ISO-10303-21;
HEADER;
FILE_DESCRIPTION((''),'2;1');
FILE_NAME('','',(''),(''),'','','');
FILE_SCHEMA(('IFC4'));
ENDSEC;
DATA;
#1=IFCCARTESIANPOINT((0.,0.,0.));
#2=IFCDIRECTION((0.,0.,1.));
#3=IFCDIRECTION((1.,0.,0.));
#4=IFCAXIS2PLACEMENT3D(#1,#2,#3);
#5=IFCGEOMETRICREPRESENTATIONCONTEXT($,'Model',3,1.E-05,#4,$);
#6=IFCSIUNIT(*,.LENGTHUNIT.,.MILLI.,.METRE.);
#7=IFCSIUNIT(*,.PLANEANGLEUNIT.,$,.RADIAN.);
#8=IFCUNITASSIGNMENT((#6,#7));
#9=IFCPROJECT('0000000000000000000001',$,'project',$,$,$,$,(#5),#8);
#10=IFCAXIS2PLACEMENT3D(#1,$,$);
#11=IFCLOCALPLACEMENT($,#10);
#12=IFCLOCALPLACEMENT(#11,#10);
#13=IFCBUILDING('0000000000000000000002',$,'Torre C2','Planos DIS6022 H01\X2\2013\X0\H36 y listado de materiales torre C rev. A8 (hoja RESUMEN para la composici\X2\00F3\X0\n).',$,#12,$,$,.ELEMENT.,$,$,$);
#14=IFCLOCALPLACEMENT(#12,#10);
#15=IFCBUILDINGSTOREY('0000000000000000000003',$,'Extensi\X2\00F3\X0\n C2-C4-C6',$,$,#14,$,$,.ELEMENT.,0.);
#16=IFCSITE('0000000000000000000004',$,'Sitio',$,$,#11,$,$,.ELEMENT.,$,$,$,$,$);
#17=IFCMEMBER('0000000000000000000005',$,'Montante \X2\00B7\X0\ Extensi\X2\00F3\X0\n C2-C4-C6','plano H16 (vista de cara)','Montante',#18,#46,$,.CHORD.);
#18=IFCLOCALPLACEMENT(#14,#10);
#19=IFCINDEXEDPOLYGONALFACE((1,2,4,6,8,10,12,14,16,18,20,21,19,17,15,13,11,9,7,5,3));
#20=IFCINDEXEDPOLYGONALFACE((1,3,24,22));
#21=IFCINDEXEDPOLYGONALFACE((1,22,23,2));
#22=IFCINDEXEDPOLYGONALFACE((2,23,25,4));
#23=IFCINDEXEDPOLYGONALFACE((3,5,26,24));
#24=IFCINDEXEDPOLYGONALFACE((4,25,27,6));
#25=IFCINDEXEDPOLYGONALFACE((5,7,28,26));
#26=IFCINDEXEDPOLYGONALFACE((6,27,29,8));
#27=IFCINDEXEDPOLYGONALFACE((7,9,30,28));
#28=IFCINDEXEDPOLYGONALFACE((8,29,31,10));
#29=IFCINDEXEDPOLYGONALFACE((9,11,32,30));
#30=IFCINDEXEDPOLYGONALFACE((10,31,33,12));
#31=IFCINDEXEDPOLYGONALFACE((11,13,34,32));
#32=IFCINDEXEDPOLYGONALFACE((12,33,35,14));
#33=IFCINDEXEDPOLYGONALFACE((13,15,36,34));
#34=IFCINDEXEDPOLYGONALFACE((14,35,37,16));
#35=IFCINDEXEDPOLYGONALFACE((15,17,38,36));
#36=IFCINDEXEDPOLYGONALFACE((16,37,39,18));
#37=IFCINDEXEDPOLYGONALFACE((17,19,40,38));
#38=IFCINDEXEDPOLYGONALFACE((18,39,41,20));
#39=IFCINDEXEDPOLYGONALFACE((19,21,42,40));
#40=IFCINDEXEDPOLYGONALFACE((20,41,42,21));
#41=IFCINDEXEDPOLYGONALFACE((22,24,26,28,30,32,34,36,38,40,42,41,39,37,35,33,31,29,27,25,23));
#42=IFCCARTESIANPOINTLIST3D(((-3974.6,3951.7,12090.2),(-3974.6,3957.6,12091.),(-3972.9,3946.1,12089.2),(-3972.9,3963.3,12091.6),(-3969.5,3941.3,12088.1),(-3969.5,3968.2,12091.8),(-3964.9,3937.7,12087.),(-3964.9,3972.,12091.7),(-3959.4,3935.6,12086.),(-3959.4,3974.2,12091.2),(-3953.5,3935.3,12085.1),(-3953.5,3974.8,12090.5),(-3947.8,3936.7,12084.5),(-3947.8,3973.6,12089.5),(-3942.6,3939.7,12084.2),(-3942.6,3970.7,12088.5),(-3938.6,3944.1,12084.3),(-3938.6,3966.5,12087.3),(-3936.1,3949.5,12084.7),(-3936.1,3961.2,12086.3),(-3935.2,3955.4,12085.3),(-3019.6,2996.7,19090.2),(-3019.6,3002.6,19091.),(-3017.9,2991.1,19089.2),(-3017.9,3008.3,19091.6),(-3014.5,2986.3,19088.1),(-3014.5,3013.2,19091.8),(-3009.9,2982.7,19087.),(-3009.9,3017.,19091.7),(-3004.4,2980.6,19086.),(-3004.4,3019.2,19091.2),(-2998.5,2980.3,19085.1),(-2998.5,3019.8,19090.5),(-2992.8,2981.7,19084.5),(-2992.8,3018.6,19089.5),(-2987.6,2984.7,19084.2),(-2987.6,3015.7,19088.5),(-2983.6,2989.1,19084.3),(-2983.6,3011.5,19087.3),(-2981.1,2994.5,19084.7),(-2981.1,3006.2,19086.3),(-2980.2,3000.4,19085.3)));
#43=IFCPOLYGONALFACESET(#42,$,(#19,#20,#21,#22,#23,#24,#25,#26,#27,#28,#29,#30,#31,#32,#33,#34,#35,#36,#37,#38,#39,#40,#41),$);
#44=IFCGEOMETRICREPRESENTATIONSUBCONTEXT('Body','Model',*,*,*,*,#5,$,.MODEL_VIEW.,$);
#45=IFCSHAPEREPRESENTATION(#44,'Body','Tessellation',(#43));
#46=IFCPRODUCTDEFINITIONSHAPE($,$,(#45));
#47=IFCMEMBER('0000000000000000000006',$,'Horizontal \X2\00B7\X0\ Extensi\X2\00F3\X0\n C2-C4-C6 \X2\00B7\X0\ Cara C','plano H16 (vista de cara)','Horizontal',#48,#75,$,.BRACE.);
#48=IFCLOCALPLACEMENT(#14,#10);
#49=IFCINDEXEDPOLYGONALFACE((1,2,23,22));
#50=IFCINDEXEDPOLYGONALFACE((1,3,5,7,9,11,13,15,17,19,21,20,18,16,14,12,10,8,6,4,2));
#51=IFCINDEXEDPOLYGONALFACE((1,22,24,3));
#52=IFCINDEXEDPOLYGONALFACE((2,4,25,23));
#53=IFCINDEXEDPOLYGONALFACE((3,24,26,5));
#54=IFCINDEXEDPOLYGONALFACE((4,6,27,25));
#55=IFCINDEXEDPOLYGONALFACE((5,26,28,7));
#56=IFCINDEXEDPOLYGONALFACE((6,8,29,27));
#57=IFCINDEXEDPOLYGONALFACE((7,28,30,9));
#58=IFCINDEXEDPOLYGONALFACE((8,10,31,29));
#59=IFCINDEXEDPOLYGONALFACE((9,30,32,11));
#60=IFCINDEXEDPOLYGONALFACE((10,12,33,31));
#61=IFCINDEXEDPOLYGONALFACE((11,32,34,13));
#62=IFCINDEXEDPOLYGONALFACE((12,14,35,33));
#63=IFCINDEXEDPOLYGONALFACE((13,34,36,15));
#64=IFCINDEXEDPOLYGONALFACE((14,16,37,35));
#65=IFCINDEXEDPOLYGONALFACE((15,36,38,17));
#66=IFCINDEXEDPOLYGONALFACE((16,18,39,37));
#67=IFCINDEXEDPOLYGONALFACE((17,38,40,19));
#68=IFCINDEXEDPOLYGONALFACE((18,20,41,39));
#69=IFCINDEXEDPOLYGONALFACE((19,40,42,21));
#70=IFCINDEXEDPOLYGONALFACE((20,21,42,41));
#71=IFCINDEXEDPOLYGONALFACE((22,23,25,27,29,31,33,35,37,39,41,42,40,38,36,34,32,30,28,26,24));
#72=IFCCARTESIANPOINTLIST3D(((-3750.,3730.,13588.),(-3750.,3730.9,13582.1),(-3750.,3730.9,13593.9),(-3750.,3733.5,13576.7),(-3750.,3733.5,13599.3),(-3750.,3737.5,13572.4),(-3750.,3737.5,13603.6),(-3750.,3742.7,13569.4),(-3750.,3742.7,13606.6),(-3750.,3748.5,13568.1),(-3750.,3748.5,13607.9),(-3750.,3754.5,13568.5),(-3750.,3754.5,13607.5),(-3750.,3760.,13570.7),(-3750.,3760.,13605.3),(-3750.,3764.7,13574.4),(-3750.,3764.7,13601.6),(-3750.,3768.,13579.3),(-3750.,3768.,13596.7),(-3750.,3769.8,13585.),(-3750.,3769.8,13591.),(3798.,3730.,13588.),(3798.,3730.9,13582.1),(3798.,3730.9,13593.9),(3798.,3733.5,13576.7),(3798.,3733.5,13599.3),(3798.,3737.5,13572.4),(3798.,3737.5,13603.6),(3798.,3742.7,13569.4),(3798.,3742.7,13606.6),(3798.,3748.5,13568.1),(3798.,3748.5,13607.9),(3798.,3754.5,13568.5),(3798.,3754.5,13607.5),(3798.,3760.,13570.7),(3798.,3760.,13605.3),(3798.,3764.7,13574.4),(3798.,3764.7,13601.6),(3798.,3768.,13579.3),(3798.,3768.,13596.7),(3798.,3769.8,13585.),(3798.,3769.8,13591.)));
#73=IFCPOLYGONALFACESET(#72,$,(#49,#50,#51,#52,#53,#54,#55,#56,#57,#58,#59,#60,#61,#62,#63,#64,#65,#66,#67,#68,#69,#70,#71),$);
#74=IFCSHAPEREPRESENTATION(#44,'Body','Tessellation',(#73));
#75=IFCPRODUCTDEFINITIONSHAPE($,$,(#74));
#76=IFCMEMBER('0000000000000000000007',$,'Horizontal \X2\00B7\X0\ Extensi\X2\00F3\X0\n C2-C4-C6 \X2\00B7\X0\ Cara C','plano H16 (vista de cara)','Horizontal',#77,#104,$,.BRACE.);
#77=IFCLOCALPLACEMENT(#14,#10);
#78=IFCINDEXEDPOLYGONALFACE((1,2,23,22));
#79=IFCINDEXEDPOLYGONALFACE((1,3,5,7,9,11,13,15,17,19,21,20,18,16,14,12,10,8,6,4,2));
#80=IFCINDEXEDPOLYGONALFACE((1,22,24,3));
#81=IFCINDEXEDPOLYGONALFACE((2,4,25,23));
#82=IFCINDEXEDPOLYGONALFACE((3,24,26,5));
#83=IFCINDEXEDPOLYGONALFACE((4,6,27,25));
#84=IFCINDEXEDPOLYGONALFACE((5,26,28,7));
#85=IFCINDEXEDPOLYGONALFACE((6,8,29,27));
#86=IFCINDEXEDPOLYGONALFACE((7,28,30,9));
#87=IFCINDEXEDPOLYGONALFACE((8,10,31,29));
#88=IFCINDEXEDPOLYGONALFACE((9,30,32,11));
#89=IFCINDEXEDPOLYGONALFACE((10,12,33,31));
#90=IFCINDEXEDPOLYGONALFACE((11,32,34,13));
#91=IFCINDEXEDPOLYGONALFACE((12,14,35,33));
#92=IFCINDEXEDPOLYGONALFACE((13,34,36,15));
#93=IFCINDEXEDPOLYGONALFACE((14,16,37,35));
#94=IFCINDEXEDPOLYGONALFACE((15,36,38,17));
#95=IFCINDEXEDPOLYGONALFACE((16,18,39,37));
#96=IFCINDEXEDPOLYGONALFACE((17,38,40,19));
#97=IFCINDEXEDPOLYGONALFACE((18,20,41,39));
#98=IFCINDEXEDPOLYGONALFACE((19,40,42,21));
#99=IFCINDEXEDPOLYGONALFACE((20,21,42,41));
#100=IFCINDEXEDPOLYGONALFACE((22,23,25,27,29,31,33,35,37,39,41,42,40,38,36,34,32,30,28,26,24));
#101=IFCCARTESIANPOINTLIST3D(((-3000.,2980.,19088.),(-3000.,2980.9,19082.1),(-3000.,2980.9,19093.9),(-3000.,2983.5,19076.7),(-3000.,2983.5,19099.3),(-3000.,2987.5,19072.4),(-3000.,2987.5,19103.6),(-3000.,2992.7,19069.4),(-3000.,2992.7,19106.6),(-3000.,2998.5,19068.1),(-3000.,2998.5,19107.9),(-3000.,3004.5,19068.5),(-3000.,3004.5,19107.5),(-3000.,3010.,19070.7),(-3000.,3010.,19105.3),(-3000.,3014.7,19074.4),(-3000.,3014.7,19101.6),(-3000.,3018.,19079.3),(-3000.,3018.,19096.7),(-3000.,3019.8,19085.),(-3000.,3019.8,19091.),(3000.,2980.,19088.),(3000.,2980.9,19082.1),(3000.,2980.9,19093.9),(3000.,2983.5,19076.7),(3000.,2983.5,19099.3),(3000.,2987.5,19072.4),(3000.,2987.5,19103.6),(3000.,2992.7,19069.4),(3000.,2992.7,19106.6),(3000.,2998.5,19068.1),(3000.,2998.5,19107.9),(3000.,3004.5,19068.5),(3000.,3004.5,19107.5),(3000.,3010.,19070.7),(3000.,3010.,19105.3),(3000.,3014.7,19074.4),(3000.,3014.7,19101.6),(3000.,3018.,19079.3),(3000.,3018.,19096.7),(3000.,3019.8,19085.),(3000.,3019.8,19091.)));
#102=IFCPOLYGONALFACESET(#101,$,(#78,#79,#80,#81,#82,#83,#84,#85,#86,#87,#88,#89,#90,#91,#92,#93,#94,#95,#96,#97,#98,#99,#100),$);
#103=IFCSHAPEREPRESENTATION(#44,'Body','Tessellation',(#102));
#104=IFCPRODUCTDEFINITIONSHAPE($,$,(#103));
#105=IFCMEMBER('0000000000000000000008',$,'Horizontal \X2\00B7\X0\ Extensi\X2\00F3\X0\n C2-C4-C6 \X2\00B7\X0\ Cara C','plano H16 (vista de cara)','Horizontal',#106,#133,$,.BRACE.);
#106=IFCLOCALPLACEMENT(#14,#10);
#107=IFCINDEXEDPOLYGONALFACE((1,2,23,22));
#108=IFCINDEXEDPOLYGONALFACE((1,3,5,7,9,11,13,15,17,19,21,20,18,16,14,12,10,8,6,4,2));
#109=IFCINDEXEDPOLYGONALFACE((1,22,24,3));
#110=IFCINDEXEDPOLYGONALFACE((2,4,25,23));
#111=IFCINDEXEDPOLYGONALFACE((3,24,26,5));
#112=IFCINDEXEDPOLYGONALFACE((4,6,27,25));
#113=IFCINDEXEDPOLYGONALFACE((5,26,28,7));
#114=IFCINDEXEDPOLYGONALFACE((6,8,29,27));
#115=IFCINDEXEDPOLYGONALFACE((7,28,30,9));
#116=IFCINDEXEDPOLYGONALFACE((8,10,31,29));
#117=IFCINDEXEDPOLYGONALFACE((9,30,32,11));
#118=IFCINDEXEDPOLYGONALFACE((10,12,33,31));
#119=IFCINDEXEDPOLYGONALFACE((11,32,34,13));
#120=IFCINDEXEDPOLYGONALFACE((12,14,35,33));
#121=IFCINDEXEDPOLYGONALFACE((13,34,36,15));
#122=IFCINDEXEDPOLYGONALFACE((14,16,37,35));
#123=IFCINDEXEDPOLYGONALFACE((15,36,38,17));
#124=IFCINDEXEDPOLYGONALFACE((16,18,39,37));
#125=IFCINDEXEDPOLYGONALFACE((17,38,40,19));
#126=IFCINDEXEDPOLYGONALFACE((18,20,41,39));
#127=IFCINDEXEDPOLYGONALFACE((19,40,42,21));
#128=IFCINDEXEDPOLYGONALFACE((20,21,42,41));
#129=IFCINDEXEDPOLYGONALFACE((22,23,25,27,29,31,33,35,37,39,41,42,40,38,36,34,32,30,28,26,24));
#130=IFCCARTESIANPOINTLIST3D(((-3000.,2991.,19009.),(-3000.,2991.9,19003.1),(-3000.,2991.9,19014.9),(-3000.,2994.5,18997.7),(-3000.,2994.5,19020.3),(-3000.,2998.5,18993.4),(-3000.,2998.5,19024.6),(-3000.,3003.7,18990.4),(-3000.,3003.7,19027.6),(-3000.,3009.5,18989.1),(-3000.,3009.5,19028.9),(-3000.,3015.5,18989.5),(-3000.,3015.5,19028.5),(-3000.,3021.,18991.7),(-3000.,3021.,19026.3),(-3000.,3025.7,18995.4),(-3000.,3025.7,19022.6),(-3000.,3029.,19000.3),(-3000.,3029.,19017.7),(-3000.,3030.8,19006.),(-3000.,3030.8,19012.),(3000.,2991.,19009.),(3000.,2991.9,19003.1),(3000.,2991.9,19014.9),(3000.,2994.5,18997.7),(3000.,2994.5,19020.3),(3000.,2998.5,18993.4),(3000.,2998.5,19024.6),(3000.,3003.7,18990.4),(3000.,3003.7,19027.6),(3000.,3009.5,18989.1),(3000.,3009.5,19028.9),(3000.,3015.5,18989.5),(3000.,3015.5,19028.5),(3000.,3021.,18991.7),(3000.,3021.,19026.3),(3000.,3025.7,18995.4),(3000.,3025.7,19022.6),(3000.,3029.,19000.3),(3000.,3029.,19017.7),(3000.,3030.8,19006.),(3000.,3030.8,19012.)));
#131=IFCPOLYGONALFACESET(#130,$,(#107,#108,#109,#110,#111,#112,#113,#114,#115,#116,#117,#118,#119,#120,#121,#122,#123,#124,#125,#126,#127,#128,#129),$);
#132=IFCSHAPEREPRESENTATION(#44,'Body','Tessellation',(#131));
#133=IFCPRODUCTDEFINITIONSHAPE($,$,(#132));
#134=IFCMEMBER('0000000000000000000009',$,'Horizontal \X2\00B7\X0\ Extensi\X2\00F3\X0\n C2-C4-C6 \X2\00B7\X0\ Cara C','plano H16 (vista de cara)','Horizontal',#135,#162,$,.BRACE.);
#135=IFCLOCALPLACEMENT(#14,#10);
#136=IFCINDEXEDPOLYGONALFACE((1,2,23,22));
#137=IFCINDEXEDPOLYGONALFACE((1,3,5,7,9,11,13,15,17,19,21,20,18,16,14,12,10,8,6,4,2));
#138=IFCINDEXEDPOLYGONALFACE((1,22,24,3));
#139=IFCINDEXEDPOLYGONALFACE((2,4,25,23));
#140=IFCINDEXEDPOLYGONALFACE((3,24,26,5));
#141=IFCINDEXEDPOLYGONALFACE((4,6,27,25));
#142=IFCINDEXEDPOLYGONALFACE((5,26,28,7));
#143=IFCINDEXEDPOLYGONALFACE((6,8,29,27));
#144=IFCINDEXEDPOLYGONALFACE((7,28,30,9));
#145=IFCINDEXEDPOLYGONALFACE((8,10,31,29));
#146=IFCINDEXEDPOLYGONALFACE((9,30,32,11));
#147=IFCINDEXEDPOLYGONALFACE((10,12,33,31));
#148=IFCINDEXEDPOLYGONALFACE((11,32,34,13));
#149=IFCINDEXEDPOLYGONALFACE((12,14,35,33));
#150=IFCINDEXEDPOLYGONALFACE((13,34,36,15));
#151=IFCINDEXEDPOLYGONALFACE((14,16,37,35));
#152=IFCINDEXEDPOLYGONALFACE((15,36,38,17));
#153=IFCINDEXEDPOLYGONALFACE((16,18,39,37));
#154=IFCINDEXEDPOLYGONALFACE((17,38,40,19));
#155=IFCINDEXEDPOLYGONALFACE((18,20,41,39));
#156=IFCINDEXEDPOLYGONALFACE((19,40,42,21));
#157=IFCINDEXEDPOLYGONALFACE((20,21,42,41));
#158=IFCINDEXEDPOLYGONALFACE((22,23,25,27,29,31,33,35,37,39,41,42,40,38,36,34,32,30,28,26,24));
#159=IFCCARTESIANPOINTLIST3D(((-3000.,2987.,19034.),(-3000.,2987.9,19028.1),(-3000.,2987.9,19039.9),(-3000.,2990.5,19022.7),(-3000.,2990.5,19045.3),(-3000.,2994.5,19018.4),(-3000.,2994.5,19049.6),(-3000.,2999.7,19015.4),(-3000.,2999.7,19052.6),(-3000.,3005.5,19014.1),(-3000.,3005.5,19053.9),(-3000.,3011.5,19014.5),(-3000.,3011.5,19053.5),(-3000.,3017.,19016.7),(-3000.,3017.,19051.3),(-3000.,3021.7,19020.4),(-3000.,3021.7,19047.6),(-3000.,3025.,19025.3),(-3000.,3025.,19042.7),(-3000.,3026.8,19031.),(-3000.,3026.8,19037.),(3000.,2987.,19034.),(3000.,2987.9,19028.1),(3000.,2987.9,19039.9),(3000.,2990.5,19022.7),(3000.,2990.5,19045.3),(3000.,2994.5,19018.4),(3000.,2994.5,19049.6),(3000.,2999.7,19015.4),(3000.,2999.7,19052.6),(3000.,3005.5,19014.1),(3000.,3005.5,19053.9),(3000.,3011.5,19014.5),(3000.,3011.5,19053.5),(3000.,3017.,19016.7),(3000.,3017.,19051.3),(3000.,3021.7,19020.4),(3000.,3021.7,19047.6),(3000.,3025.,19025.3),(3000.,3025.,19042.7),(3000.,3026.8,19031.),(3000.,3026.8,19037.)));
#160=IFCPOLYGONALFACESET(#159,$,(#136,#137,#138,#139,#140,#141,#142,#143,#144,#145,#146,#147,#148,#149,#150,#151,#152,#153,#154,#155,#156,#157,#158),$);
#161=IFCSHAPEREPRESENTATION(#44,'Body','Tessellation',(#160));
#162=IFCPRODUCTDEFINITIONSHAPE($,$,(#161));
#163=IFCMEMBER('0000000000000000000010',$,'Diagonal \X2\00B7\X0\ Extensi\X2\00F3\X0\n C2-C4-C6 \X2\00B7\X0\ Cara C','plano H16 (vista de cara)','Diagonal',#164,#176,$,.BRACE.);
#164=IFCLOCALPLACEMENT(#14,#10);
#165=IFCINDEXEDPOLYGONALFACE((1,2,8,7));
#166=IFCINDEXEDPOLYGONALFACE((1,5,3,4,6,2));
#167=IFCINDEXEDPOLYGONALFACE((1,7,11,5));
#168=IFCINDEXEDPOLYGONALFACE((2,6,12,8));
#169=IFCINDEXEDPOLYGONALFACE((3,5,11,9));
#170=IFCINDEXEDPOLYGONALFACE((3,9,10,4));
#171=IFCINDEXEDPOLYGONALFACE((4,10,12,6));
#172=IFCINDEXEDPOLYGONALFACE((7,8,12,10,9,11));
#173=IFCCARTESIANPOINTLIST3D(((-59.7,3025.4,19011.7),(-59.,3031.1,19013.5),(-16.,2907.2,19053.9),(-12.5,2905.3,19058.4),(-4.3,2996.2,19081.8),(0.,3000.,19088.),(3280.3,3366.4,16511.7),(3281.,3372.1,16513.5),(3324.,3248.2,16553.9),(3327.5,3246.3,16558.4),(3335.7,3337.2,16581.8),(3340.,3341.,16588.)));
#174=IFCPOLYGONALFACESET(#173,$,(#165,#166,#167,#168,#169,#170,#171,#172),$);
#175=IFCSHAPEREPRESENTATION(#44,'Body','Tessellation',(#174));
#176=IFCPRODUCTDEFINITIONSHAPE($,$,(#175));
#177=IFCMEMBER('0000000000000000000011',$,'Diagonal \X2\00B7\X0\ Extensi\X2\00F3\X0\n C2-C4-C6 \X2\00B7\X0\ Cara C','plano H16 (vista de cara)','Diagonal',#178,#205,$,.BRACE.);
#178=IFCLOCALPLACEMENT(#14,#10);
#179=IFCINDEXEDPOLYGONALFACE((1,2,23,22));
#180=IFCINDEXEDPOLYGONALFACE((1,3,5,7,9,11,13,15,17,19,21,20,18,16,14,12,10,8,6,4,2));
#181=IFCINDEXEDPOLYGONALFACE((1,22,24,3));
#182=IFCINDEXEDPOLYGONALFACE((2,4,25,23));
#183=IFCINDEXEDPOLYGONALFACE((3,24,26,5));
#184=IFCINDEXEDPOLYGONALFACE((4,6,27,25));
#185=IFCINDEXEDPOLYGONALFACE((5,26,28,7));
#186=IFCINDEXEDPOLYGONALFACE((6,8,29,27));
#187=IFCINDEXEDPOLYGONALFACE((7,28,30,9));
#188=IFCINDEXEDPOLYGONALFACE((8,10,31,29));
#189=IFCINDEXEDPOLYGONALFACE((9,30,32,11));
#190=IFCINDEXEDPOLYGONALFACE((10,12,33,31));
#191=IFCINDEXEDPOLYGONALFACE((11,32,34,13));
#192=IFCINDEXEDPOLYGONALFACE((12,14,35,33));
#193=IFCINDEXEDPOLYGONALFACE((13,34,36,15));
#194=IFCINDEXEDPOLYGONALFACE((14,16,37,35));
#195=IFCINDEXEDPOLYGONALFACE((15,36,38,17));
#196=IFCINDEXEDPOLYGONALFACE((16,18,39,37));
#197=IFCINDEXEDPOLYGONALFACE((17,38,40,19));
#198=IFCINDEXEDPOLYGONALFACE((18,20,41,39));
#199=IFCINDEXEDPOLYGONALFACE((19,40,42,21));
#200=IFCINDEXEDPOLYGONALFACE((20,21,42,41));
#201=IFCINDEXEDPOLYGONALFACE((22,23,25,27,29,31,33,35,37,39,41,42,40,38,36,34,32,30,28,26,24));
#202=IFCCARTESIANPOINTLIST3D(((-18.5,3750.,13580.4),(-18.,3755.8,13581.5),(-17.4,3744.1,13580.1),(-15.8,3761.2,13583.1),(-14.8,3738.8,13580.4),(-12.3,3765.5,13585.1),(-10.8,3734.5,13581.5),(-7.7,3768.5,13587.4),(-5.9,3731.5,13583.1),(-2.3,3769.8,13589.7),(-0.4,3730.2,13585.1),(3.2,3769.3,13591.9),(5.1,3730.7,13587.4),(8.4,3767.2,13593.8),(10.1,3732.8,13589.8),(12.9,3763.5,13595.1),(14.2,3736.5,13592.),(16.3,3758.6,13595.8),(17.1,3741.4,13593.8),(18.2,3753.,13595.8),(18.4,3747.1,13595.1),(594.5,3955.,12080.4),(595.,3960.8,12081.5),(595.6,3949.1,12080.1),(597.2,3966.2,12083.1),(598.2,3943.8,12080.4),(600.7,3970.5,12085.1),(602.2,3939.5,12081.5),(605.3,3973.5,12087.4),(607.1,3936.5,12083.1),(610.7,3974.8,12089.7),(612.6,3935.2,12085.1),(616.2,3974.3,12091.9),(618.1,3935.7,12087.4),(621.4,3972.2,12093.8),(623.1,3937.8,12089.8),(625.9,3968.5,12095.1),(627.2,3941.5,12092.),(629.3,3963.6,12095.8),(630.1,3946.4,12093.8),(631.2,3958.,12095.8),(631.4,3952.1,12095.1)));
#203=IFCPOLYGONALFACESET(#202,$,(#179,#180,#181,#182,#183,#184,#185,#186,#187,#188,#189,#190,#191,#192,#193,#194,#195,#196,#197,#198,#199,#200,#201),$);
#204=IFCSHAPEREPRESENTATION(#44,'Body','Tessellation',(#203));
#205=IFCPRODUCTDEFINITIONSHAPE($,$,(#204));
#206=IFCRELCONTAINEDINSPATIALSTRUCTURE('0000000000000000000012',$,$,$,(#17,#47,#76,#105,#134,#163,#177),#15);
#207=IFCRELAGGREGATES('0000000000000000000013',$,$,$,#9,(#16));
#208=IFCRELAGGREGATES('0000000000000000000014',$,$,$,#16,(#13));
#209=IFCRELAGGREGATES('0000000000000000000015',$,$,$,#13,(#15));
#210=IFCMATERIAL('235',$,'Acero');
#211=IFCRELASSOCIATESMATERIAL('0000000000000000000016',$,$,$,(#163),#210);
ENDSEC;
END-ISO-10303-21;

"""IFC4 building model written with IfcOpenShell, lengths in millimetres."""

from ifc_helpers import new_model, si_unit, frame, frame_2d, origin, origin_with_axes, place, context, subcontext, project, spatial, circle, l_section, extrude, material, element, save


model = new_model("IFC4")

# Units and contexts
model_context = context("Model", 3, precision=1e-05, world=origin_with_axes())
body_context = subcontext(model_context, "Body", "Model", "MODEL_VIEW")
ifc_project = project(units=[si_unit("LENGTHUNIT", "METRE", prefix="MILLI"), si_unit("PLANEANGLEUNIT", "RADIAN")], contexts=[model_context])

# Site, building, storey
site_placement = place(None, origin())
site = spatial("IfcSite", under=ifc_project, at=site_placement, Name="Sitio", CompositionType="ELEMENT")
building_placement = place(site_placement, origin())
building = spatial("IfcBuilding", under=site, at=building_placement, Name="Torre C2", Description="Planos DIS6022 H01–H36 y listado de materiales torre C rev. A8 (hoja RESUMEN para la composición).", CompositionType="ELEMENT")
storey_placement = place(building_placement, origin())
storey = spatial("IfcBuildingStorey", under=building, at=storey_placement, Name="Extensión C2-C4-C6", CompositionType="ELEMENT", Elevation=0.0)

# Members
member_1_placement = place(storey_placement, frame((-3000.0, 3000.0, 19088.0), z_axis=(-0.133958, 0.133958, -0.981891), x_axis=(0.990987, 0.018108, -0.132728)))
element("IfcMember", 1, at=member_1_placement, inside=storey, Name="Montante · Extensión C2-C4-C6", Description="plano H16 (vista de cara)", ObjectType="Montante", PredefinedType="CHORD", context=body_context, shape_type="SweptSolid", body=[
    extrude(circle(Radius=20.0), None, (0.0, 0.0, 1.0), 7129.1),
])
member_2_placement = place(storey_placement, frame((-3750.0, 3750.0, 13588.0), z_axis=(1.0, 0.0, 0.0), x_axis=(0.0, -1.0, 0.0)))
element("IfcMember", 2, at=member_2_placement, inside=storey, Name="Horizontal · Extensión C2-C4-C6 · Cara C", Description="plano H16 (vista de cara)", ObjectType="Horizontal", PredefinedType="BRACE", context=body_context, shape_type="SweptSolid", body=[
    extrude(circle(Radius=20.0), None, (0.0, 0.0, 1.0), 7548.0),
])
for number, where, z_axis, x_axis, name in (
    (3, (-3000.0, 3000.0, 19088.0), (1.0, 0.0, 0.0), (0.0, -1.0, 0.0), "Horizontal · Extensión C2-C4-C6 · Cara C"),
    (4, (-3000.0, 3011.0, 19009.0), (1.0, 0.0, 0.0), (0.0, -1.0, 0.0), "Horizontal · Extensión C2-C4-C6 · Cara C"),
    (5, (-3000.0, 3007.0, 19034.0), (1.0, 0.0, 0.0), (0.0, -1.0, 0.0), "Horizontal · Extensión C2-C4-C6 · Cara C"),
):
    element("IfcMember", number, at=place(storey_placement, frame(where, z_axis=z_axis, x_axis=x_axis)), inside=storey, Name=name, Description="plano H16 (vista de cara)", ObjectType="Horizontal", PredefinedType="BRACE", context=body_context, shape_type="SweptSolid", body=[
        extrude(circle(Radius=20.0), None, (0.0, 0.0, 1.0), 6000.0),
    ])
ifc_material_1 = material(Name="235", Category="Acero")
member_3_placement = place(storey_placement, frame((0.0, 3000.0, 19088.0), z_axis=(0.797914, 0.081464, -0.597241), x_axis=(-0.124785, -0.947037, -0.295888)))
element("IfcMember", 6, at=member_3_placement, inside=storey, material=ifc_material_1, Name="Diagonal · Extensión C2-C4-C6 · Cara C", Description="plano H16 (vista de cara)", ObjectType="Diagonal", PredefinedType="BRACE", context=body_context, shape_type="SweptSolid", body=[
    extrude(l_section(Depth=100.0, Width=100.0, Thickness=6.0, at=frame_2d((50.0, 50.0))), None, (0.0, 0.0, 1.0), 4185.9),
])
member_4_placement = place(storey_placement, frame((0.0, 3750.0, 13588.0), z_axis=(0.375305, 0.12551, -0.918365), x_axis=(-0.02144, -0.989349, -0.143973)))
element("IfcMember", 7, at=member_4_placement, inside=storey, Name="Diagonal · Extensión C2-C4-C6 · Cara C", Description="plano H16 (vista de cara)", ObjectType="Diagonal", PredefinedType="BRACE", context=body_context, shape_type="SweptSolid", body=[
    extrude(circle(Radius=20.0), None, (0.0, 0.0, 1.0), 1633.3),
])

save(model, "model.ifc")
